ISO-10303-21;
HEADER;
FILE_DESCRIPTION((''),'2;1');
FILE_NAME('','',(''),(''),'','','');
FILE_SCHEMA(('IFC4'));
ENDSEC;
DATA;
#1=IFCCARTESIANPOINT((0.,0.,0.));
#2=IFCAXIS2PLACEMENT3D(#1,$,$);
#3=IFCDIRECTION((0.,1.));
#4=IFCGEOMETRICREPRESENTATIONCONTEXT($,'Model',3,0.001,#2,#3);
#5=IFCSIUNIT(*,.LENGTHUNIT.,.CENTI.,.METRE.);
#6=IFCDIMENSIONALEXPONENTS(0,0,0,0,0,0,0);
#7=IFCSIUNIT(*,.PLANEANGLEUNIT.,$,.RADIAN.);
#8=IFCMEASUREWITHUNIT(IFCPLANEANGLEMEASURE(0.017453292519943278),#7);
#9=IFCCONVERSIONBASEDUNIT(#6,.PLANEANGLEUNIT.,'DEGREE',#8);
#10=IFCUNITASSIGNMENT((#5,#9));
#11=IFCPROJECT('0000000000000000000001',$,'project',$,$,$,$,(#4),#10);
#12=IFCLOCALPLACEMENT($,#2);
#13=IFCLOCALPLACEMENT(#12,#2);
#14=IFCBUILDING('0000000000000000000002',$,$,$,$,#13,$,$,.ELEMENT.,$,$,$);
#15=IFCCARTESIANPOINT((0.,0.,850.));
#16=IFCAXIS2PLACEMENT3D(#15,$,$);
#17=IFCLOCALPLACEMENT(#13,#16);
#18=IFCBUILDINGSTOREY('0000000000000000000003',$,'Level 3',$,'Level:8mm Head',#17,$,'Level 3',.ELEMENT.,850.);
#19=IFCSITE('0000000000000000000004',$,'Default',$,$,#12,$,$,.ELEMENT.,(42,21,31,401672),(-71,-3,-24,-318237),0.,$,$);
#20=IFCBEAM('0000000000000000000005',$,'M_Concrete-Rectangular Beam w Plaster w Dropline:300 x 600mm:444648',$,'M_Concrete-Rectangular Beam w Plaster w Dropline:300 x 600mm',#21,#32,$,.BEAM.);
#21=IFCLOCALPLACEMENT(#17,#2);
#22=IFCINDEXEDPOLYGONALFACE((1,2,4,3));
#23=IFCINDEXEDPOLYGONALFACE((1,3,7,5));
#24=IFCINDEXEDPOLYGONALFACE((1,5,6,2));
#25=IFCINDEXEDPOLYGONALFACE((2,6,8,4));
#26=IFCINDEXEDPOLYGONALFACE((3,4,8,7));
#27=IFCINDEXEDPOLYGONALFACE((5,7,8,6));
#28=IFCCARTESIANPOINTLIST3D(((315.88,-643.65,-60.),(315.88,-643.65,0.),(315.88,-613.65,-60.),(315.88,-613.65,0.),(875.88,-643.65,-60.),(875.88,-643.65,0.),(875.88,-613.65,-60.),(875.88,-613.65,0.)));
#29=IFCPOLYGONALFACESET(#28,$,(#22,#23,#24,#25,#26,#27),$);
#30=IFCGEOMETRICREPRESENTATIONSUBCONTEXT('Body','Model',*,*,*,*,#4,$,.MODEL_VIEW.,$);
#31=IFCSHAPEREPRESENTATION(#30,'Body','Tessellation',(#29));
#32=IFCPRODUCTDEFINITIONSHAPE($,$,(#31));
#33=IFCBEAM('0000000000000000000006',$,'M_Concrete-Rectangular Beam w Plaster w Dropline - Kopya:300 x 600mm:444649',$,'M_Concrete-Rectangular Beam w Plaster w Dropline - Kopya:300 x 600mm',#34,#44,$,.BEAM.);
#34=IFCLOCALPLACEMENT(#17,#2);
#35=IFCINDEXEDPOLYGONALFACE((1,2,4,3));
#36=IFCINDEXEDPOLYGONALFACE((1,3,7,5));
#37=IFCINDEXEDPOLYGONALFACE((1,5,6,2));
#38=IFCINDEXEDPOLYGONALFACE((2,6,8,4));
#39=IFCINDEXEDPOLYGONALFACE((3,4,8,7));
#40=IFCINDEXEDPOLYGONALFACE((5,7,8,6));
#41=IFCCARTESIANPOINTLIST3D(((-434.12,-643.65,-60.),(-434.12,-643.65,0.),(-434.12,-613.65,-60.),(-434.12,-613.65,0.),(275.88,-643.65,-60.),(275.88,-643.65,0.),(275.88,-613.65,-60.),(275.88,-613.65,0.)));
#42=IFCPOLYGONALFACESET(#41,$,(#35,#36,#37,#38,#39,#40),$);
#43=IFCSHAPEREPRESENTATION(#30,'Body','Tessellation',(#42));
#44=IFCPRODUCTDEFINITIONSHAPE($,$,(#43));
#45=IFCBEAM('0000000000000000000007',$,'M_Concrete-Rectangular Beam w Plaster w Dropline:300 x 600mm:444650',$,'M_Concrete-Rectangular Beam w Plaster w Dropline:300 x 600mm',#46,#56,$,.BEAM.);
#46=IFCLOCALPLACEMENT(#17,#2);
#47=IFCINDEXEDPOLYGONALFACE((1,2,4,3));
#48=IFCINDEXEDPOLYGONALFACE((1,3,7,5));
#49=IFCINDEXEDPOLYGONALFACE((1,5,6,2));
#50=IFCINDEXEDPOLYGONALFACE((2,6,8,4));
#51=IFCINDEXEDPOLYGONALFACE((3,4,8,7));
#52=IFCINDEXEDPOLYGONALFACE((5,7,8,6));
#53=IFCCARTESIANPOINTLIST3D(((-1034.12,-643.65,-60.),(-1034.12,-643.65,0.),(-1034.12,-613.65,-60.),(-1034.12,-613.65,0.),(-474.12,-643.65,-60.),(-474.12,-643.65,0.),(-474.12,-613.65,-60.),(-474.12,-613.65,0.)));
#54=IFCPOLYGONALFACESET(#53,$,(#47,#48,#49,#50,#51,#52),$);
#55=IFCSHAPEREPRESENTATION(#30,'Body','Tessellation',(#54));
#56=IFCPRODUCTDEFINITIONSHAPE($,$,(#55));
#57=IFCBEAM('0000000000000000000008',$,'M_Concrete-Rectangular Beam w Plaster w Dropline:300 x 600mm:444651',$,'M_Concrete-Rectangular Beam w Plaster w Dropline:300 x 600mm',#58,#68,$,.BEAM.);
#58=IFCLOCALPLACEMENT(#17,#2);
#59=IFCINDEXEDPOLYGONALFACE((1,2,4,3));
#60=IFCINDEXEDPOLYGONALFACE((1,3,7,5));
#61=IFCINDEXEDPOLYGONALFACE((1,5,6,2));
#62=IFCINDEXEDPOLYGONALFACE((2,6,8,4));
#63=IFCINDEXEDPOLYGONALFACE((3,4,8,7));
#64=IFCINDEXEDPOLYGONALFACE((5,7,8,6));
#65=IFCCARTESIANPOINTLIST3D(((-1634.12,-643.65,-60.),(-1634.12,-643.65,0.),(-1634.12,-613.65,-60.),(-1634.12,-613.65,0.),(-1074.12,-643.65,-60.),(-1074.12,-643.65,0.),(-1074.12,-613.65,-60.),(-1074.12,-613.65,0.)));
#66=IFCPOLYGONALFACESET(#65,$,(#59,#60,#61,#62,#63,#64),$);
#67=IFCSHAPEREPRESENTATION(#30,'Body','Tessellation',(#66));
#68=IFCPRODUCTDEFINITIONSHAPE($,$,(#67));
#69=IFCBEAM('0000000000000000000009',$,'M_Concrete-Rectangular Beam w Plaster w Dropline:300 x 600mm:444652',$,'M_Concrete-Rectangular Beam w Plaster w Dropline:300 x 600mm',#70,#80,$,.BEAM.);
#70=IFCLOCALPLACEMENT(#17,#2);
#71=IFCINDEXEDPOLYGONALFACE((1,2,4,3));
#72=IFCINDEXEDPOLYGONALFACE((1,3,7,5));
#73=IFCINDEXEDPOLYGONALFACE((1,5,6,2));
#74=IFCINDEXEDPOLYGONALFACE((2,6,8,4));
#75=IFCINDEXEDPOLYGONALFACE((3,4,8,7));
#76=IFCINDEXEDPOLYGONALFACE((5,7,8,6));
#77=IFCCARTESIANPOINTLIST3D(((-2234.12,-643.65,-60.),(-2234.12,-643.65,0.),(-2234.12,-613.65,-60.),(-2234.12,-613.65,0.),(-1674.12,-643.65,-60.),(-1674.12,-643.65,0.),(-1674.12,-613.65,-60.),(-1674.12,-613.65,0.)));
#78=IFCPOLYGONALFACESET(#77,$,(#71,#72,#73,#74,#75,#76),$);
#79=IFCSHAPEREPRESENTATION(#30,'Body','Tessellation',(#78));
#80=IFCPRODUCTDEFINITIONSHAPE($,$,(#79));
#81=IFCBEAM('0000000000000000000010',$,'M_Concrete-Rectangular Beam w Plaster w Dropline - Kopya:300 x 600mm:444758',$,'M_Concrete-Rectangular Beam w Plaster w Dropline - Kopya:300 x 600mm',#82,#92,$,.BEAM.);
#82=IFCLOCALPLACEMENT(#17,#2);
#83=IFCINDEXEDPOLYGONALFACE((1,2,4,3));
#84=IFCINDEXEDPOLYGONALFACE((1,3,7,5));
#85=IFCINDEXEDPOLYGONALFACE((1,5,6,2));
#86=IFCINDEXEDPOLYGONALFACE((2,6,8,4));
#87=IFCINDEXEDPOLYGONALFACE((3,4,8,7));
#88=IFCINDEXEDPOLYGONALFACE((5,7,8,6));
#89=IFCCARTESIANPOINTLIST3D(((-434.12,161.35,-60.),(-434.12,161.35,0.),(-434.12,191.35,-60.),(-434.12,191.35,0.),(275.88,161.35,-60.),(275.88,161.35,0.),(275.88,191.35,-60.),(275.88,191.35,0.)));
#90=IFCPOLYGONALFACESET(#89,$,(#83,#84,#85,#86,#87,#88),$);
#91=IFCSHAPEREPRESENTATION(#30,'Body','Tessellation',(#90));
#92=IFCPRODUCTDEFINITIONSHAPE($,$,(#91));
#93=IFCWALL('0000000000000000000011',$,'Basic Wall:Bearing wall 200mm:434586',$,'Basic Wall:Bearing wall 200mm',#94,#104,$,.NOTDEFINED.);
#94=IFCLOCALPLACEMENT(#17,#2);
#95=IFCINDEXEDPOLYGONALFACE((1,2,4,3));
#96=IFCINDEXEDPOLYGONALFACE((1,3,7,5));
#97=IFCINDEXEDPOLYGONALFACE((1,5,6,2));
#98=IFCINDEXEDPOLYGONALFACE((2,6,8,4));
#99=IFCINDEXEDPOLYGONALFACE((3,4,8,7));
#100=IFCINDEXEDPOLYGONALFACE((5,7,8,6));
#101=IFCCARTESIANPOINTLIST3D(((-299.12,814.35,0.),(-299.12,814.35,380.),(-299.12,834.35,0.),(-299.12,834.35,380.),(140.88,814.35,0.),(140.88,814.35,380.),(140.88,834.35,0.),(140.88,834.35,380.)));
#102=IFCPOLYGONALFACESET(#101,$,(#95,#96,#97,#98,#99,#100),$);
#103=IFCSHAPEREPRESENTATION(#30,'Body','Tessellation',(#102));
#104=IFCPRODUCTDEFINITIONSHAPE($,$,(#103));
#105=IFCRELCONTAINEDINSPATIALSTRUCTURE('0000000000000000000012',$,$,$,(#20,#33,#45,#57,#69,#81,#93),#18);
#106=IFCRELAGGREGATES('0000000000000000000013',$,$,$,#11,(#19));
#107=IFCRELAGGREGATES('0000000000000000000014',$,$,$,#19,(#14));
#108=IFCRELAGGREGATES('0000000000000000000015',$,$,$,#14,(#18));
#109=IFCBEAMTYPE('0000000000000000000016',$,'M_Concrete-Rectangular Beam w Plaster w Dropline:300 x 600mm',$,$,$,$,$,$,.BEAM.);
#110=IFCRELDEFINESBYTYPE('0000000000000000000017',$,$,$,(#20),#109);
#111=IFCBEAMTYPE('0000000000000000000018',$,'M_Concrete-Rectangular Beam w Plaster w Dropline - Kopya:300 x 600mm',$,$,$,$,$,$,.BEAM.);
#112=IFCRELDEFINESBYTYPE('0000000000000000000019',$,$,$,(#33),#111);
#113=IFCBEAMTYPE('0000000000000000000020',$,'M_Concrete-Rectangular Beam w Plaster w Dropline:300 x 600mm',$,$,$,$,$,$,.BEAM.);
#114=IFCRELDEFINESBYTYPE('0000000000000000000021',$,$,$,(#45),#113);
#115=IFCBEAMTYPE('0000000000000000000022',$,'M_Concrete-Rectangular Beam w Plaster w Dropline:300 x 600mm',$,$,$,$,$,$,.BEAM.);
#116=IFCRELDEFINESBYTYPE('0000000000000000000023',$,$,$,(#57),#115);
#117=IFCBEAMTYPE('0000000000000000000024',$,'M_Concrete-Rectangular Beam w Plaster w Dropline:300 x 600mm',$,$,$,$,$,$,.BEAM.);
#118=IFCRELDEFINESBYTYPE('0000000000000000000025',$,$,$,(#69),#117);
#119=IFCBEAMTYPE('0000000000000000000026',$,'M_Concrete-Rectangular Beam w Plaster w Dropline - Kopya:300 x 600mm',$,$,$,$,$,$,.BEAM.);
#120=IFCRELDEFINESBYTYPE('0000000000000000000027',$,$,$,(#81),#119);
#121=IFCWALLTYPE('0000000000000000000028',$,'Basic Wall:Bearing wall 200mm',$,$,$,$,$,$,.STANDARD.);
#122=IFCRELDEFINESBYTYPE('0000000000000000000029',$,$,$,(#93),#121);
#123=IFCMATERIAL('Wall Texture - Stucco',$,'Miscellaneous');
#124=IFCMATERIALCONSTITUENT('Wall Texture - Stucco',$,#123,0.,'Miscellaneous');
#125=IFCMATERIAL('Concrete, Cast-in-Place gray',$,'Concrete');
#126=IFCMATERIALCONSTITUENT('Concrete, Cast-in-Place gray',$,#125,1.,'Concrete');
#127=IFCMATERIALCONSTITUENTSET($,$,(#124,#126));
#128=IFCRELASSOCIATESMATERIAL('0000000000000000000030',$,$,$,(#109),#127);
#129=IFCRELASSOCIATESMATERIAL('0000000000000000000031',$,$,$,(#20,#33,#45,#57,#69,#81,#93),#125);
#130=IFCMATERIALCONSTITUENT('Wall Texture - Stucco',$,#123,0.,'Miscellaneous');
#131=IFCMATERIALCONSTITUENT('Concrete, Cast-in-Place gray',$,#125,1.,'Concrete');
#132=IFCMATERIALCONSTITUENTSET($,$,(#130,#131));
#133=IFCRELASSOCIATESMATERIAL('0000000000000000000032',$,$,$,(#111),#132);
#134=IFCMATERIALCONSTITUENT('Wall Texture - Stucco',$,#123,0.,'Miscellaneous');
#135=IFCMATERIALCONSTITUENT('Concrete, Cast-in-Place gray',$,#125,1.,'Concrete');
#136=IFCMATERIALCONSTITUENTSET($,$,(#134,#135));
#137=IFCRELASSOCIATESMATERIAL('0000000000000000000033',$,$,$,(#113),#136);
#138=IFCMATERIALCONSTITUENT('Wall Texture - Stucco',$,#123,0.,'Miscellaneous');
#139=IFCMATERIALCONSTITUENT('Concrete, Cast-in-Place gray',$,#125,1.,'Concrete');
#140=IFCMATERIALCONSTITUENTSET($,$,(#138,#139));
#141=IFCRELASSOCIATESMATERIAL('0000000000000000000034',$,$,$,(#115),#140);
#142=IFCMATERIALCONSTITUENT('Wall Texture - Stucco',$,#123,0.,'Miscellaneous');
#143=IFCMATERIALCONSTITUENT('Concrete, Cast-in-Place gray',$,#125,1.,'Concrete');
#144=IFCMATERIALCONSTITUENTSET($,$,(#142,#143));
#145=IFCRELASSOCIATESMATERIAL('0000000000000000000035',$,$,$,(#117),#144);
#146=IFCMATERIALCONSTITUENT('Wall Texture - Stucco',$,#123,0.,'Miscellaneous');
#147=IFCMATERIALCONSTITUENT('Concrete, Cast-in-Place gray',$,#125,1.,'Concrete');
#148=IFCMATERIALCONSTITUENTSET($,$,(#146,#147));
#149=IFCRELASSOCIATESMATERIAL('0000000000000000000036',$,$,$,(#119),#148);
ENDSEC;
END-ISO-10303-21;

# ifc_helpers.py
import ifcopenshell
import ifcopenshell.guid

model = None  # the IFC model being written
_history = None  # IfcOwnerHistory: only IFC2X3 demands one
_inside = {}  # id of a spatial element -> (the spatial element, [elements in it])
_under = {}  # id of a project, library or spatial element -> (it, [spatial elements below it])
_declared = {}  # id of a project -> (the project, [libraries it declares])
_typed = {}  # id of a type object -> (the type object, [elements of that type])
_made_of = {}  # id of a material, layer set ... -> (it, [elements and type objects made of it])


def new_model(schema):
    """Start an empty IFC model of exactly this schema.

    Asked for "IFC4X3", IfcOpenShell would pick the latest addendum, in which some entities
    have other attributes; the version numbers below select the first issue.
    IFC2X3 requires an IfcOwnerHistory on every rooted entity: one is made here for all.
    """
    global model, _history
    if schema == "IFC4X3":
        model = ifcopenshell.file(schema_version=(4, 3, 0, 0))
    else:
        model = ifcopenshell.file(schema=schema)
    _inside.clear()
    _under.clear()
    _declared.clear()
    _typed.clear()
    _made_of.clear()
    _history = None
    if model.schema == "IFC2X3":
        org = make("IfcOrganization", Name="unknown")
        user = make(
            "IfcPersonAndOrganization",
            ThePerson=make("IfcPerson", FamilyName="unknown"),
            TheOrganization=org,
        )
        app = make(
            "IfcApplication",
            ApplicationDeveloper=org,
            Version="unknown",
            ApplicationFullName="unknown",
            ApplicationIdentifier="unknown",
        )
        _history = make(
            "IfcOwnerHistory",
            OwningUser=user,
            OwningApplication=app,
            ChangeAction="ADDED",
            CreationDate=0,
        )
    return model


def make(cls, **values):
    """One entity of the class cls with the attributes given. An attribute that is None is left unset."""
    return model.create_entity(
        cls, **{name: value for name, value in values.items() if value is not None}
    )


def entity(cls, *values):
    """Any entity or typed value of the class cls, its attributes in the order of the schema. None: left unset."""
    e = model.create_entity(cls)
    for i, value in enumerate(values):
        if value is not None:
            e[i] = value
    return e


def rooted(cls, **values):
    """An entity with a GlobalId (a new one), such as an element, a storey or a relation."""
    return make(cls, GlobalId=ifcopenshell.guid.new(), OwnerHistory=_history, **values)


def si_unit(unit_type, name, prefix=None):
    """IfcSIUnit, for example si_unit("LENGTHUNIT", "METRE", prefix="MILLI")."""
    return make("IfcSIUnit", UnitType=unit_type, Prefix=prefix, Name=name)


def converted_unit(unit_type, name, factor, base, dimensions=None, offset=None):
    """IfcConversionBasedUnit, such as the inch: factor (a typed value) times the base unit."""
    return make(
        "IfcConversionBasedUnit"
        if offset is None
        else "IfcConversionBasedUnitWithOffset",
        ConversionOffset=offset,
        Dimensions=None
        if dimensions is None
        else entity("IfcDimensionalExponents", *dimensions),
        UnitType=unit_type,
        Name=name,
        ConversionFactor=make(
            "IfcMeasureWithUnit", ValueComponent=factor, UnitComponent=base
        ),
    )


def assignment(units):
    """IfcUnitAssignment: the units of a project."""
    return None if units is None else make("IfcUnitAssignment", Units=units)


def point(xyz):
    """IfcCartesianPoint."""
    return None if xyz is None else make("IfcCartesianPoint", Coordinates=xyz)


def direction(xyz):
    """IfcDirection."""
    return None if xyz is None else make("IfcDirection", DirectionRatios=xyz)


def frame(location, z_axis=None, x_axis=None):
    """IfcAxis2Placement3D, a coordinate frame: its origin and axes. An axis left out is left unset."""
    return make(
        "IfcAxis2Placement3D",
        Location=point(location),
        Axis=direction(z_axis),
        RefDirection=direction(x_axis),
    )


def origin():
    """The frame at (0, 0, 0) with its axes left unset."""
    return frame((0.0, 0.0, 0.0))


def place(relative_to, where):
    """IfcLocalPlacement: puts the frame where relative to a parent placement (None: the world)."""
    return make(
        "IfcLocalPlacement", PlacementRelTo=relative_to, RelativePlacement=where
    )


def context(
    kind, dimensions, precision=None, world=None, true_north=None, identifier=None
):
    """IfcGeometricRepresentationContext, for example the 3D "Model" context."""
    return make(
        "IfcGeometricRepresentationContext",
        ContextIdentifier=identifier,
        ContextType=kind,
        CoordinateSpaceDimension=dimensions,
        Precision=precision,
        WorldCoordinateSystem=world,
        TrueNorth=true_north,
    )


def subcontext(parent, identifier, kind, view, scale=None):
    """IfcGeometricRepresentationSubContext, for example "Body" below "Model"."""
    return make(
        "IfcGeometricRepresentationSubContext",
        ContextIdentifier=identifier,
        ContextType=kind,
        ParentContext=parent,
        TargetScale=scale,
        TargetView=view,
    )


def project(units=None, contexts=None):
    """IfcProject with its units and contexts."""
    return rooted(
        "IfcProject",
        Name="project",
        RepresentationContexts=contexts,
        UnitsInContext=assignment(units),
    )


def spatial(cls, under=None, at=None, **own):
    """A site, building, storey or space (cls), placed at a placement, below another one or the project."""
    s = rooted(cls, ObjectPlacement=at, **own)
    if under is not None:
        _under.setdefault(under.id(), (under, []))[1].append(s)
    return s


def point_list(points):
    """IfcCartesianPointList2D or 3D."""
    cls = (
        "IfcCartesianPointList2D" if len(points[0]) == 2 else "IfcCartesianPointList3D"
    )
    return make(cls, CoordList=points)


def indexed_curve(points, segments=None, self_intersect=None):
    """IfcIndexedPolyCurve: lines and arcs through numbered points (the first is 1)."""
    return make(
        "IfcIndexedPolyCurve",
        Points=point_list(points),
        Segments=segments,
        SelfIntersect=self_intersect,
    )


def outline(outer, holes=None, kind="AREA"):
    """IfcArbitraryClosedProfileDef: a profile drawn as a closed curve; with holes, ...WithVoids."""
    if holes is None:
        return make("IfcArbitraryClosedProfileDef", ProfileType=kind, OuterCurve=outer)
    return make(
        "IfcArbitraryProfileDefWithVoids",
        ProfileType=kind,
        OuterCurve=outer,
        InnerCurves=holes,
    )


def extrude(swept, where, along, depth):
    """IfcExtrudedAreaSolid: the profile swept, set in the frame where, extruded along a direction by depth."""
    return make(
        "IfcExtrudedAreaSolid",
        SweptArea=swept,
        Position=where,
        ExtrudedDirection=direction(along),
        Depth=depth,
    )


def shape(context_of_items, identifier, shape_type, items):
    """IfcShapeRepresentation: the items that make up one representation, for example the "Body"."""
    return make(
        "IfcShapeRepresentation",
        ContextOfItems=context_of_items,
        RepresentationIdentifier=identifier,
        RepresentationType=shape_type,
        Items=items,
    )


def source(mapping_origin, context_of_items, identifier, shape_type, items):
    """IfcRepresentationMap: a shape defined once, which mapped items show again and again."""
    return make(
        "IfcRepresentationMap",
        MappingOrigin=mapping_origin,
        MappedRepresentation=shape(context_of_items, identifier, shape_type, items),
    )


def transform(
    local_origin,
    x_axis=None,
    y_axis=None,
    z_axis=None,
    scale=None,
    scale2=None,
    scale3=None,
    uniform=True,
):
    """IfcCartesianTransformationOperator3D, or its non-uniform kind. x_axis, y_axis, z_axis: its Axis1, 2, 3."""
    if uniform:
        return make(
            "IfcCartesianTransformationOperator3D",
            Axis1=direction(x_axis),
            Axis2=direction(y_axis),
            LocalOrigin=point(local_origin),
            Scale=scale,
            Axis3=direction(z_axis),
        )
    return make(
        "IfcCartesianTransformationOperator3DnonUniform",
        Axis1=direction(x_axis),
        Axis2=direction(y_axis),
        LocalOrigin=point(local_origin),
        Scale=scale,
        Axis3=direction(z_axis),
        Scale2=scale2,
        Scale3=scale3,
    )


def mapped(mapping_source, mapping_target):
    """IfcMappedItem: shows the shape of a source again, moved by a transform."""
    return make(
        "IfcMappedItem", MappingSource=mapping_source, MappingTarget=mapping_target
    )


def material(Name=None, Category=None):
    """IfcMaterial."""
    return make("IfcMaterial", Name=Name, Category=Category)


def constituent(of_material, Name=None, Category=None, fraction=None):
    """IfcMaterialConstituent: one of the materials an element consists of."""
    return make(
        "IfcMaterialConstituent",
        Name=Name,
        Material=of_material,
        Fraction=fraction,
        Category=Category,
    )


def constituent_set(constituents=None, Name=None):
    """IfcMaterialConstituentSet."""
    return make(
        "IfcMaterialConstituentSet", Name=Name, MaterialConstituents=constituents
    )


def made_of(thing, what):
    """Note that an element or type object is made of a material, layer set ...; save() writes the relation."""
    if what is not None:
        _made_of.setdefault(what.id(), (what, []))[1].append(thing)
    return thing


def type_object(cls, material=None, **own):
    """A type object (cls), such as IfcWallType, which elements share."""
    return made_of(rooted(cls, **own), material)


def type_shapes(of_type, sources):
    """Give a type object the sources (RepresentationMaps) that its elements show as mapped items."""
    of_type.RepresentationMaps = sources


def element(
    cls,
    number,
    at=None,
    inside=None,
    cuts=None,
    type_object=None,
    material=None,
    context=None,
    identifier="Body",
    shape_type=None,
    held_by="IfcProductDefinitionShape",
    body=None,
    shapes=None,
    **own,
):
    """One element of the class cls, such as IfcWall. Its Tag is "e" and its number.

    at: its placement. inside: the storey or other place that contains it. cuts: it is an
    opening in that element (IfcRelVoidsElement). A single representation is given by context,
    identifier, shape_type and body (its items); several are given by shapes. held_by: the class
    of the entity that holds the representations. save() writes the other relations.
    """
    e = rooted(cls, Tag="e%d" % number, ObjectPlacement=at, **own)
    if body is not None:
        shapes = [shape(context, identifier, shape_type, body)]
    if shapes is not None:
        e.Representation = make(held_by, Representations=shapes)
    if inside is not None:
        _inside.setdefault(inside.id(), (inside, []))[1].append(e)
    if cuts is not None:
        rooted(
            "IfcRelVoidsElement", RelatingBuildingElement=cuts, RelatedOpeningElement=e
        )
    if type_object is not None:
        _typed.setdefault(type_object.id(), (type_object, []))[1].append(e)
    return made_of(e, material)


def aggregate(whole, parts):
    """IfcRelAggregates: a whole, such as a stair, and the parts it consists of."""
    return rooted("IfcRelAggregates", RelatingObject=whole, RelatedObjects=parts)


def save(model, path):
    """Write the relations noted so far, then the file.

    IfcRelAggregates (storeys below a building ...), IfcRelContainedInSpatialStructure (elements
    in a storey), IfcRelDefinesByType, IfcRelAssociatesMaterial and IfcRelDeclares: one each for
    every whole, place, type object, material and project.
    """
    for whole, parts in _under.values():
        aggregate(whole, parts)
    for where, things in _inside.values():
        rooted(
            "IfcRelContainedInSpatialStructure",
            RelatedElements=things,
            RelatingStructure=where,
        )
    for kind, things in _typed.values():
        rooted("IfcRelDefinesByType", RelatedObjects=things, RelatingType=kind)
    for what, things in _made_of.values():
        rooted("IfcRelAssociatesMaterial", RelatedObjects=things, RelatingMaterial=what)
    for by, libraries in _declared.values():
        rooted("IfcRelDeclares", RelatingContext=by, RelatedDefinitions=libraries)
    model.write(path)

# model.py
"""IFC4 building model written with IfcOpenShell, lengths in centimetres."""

from ifc_helpers import new_model, entity, si_unit, converted_unit, direction, frame, origin, place, context, subcontext, project, spatial, indexed_curve, outline, extrude, source, transform, mapped, material, constituent, constituent_set, type_object, type_shapes, element, save


model = new_model("IFC4")

# Units and contexts
model_context = context("Model", 3, precision=0.001, world=origin(), true_north=direction((0.0, 1.0)))
body_context = subcontext(model_context, "Body", "Model", "MODEL_VIEW")
ifc_project = project(units=[si_unit("LENGTHUNIT", "METRE", prefix="CENTI"), converted_unit("PLANEANGLEUNIT", "DEGREE", entity("IfcPlaneAngleMeasure", 0.017453292519943278), si_unit("PLANEANGLEUNIT", "RADIAN"), dimensions=[0, 0, 0, 0, 0, 0, 0])], contexts=[model_context])

# Site, building, storey
site_placement = place(None, origin())
site = spatial("IfcSite", under=ifc_project, at=site_placement, Name="Default", CompositionType="ELEMENT", RefLatitude=(42, 21, 31, 401672), RefLongitude=(-71, -3, -24, -318237), RefElevation=0.0)
building_placement = place(site_placement, origin())
building = spatial("IfcBuilding", under=site, at=building_placement, CompositionType="ELEMENT")
storey_placement = place(building_placement, frame((0.0, 0.0, 850.0)))
storey = spatial("IfcBuildingStorey", under=building, at=storey_placement, Name="Level 3", ObjectType="Level:8mm Head", LongName="Level 3", CompositionType="ELEMENT", Elevation=850.0)

# Beams
ifc_material_1 = material(Name="Concrete, Cast-in-Place gray", Category="Concrete")
ifc_material_2 = material(Name="Wall Texture - Stucco", Category="Miscellaneous")
ifc_constituent_1 = constituent(ifc_material_2, Name="Wall Texture - Stucco", Category="Miscellaneous", fraction=0.0)
ifc_constituent_2 = constituent(ifc_material_1, Name="Concrete, Cast-in-Place gray", Category="Concrete", fraction=1.0)
ifc_constituent_set_1 = constituent_set(constituents=[ifc_constituent_1, ifc_constituent_2])
beam_type_1 = type_object("IfcBeamType", Name="M_Concrete-Rectangular Beam w Plaster w Dropline:300 x 600mm", PredefinedType="BEAM", material=ifc_constituent_set_1)
shared_shape_1 = source(origin(), body_context, "Body", "SweptSolid", [
    extrude(outline(indexed_curve([(-30.0, -15.0), (30.0, -15.0), (30.0, 15.0), (-30.0, 15.0), (-30.0, -15.0)], self_intersect=False)), frame((875.88, -628.65, 820.0), z_axis=(-1.0, 0.0, 0.0), x_axis=(0.0, 0.0, -1.0)), (0.0, 0.0, 1.0), 560.0),
])
type_shapes(beam_type_1, [shared_shape_1])
beam_1_placement = place(storey_placement, frame((0.0, 0.0, -850.0)))
element("IfcBeam", 1, at=beam_1_placement, inside=storey, type_object=beam_type_1, material=ifc_material_1, Name="M_Concrete-Rectangular Beam w Plaster w Dropline:300 x 600mm:444648", ObjectType="M_Concrete-Rectangular Beam w Plaster w Dropline:300 x 600mm", PredefinedType="BEAM", context=body_context, shape_type="MappedRepresentation", body=[
    mapped(shared_shape_1, transform((0.0, 0.0, 0.0), scale=1.0)),
])
ifc_constituent_3 = constituent(ifc_material_2, Name="Wall Texture - Stucco", Category="Miscellaneous", fraction=0.0)
ifc_constituent_4 = constituent(ifc_material_1, Name="Concrete, Cast-in-Place gray", Category="Concrete", fraction=1.0)
ifc_constituent_set_2 = constituent_set(constituents=[ifc_constituent_3, ifc_constituent_4])
beam_type_2 = type_object("IfcBeamType", Name="M_Concrete-Rectangular Beam w Plaster w Dropline - Kopya:300 x 600mm", PredefinedType="BEAM", material=ifc_constituent_set_2)
shared_shape_2 = source(origin(), body_context, "Body", "SweptSolid", [
    extrude(outline(indexed_curve([(-30.0, -15.0), (30.0, -15.0), (30.0, 15.0), (-30.0, 15.0), (-30.0, -15.0)], self_intersect=False)), frame((275.88, -628.65, 820.0), z_axis=(-1.0, 0.0, 0.0), x_axis=(0.0, 0.0, -1.0)), (0.0, 0.0, 1.0), 710.0),
])
type_shapes(beam_type_2, [shared_shape_2])
beam_2_placement = place(storey_placement, frame((0.0, 0.0, -850.0)))
element("IfcBeam", 2, at=beam_2_placement, inside=storey, type_object=beam_type_2, material=ifc_material_1, Name="M_Concrete-Rectangular Beam w Plaster w Dropline - Kopya:300 x 600mm:444649", ObjectType="M_Concrete-Rectangular Beam w Plaster w Dropline - Kopya:300 x 600mm", PredefinedType="BEAM", context=body_context, shape_type="MappedRepresentation", body=[
    mapped(shared_shape_2, transform((0.0, 0.0, 0.0), scale=1.0)),
])
ifc_constituent_5 = constituent(ifc_material_2, Name="Wall Texture - Stucco", Category="Miscellaneous", fraction=0.0)
ifc_constituent_6 = constituent(ifc_material_1, Name="Concrete, Cast-in-Place gray", Category="Concrete", fraction=1.0)
ifc_constituent_set_3 = constituent_set(constituents=[ifc_constituent_5, ifc_constituent_6])
beam_type_3 = type_object("IfcBeamType", Name="M_Concrete-Rectangular Beam w Plaster w Dropline:300 x 600mm", PredefinedType="BEAM", material=ifc_constituent_set_3)
shared_shape_3 = source(origin(), body_context, "Body", "SweptSolid", [
    extrude(outline(indexed_curve([(-30.0, -15.0), (30.0, -15.0), (30.0, 15.0), (-30.0, 15.0), (-30.0, -15.0)], self_intersect=False)), frame((-474.12, -628.65, 820.0), z_axis=(-1.0, 0.0, 0.0), x_axis=(0.0, 0.0, -1.0)), (0.0, 0.0, 1.0), 560.0),
])
type_shapes(beam_type_3, [shared_shape_3])
beam_3_placement = place(storey_placement, frame((0.0, 0.0, -850.0)))
element("IfcBeam", 3, at=beam_3_placement, inside=storey, type_object=beam_type_3, material=ifc_material_1, Name="M_Concrete-Rectangular Beam w Plaster w Dropline:300 x 600mm:444650", ObjectType="M_Concrete-Rectangular Beam w Plaster w Dropline:300 x 600mm", PredefinedType="BEAM", context=body_context, shape_type="MappedRepresentation", body=[
    mapped(shared_shape_3, transform((0.0, 0.0, 0.0), scale=1.0)),
])
ifc_constituent_7 = constituent(ifc_material_2, Name="Wall Texture - Stucco", Category="Miscellaneous", fraction=0.0)
ifc_constituent_8 = constituent(ifc_material_1, Name="Concrete, Cast-in-Place gray", Category="Concrete", fraction=1.0)
ifc_constituent_set_4 = constituent_set(constituents=[ifc_constituent_7, ifc_constituent_8])
beam_type_4 = type_object("IfcBeamType", Name="M_Concrete-Rectangular Beam w Plaster w Dropline:300 x 600mm", PredefinedType="BEAM", material=ifc_constituent_set_4)
shared_shape_4 = source(origin(), body_context, "Body", "SweptSolid", [
    extrude(outline(indexed_curve([(-30.0, -15.0), (30.0, -15.0), (30.0, 15.0), (-30.0, 15.0), (-30.0, -15.0)], self_intersect=False)), frame((-1074.12, -628.65, 820.0), z_axis=(-1.0, 0.0, 0.0), x_axis=(0.0, 0.0, -1.0)), (0.0, 0.0, 1.0), 560.0),
])
type_shapes(beam_type_4, [shared_shape_4])
beam_4_placement = place(storey_placement, frame((0.0, 0.0, -850.0)))
element("IfcBeam", 4, at=beam_4_placement, inside=storey, type_object=beam_type_4, material=ifc_material_1, Name="M_Concrete-Rectangular Beam w Plaster w Dropline:300 x 600mm:444651", ObjectType="M_Concrete-Rectangular Beam w Plaster w Dropline:300 x 600mm", PredefinedType="BEAM", context=body_context, shape_type="MappedRepresentation", body=[
    mapped(shared_shape_4, transform((0.0, 0.0, 0.0), scale=1.0)),
])
ifc_constituent_9 = constituent(ifc_material_2, Name="Wall Texture - Stucco", Category="Miscellaneous", fraction=0.0)
ifc_constituent_10 = constituent(ifc_material_1, Name="Concrete, Cast-in-Place gray", Category="Concrete", fraction=1.0)
ifc_constituent_set_5 = constituent_set(constituents=[ifc_constituent_9, ifc_constituent_10])
beam_type_5 = type_object("IfcBeamType", Name="M_Concrete-Rectangular Beam w Plaster w Dropline:300 x 600mm", PredefinedType="BEAM", material=ifc_constituent_set_5)
shared_shape_5 = source(origin(), body_context, "Body", "SweptSolid", [
    extrude(outline(indexed_curve([(-30.0, -15.0), (30.0, -15.0), (30.0, 15.0), (-30.0, 15.0), (-30.0, -15.0)], self_intersect=False)), frame((-1674.12, -628.65, 820.0), z_axis=(-1.0, 0.0, 0.0), x_axis=(0.0, 0.0, -1.0)), (0.0, 0.0, 1.0), 560.0),
])
type_shapes(beam_type_5, [shared_shape_5])
beam_5_placement = place(storey_placement, frame((0.0, 0.0, -850.0)))
element("IfcBeam", 5, at=beam_5_placement, inside=storey, type_object=beam_type_5, material=ifc_material_1, Name="M_Concrete-Rectangular Beam w Plaster w Dropline:300 x 600mm:444652", ObjectType="M_Concrete-Rectangular Beam w Plaster w Dropline:300 x 600mm", PredefinedType="BEAM", context=body_context, shape_type="MappedRepresentation", body=[
    mapped(shared_shape_5, transform((0.0, 0.0, 0.0), scale=1.0)),
])
ifc_constituent_11 = constituent(ifc_material_2, Name="Wall Texture - Stucco", Category="Miscellaneous", fraction=0.0)
ifc_constituent_12 = constituent(ifc_material_1, Name="Concrete, Cast-in-Place gray", Category="Concrete", fraction=1.0)
ifc_constituent_set_6 = constituent_set(constituents=[ifc_constituent_11, ifc_constituent_12])
beam_type_6 = type_object("IfcBeamType", Name="M_Concrete-Rectangular Beam w Plaster w Dropline - Kopya:300 x 600mm", PredefinedType="BEAM", material=ifc_constituent_set_6)
shared_shape_6 = source(origin(), body_context, "Body", "SweptSolid", [
    extrude(outline(indexed_curve([(-30.0, -15.0), (30.0, -15.0), (30.0, 15.0), (-30.0, 15.0), (-30.0, -15.0)], self_intersect=False)), frame((275.88, 176.35, 820.0), z_axis=(-1.0, 0.0, 0.0), x_axis=(0.0, 0.0, -1.0)), (0.0, 0.0, 1.0), 710.0),
])
type_shapes(beam_type_6, [shared_shape_6])
beam_6_placement = place(storey_placement, frame((0.0, 0.0, -850.0)))
element("IfcBeam", 6, at=beam_6_placement, inside=storey, type_object=beam_type_6, material=ifc_material_1, Name="M_Concrete-Rectangular Beam w Plaster w Dropline - Kopya:300 x 600mm:444758", ObjectType="M_Concrete-Rectangular Beam w Plaster w Dropline - Kopya:300 x 600mm", PredefinedType="BEAM", context=body_context, shape_type="MappedRepresentation", body=[
    mapped(shared_shape_6, transform((0.0, 0.0, 0.0), scale=1.0)),
])

# Wall
wall_type = type_object("IfcWallType", Name="Basic Wall:Bearing wall 200mm", PredefinedType="STANDARD")
wall_placement = place(storey_placement, frame((140.88, 824.35, 0.0), z_axis=(0.0, 0.0, 1.0), x_axis=(-1.0, 0.0, 0.0)))
element("IfcWall", 7, at=wall_placement, inside=storey, type_object=wall_type, material=ifc_material_1, Name="Basic Wall:Bearing wall 200mm:434586", ObjectType="Basic Wall:Bearing wall 200mm", PredefinedType="NOTDEFINED", context=body_context, shape_type="SweptSolid", body=[
    extrude(outline(indexed_curve([(440.0, 10.0), (0.0, 10.0), (0.0, -10.0), (440.0, -10.0), (440.0, 10.0)], self_intersect=False)), origin(), (0.0, 0.0, 1.0), 380.0),
])

save(model, "model.ifc")
